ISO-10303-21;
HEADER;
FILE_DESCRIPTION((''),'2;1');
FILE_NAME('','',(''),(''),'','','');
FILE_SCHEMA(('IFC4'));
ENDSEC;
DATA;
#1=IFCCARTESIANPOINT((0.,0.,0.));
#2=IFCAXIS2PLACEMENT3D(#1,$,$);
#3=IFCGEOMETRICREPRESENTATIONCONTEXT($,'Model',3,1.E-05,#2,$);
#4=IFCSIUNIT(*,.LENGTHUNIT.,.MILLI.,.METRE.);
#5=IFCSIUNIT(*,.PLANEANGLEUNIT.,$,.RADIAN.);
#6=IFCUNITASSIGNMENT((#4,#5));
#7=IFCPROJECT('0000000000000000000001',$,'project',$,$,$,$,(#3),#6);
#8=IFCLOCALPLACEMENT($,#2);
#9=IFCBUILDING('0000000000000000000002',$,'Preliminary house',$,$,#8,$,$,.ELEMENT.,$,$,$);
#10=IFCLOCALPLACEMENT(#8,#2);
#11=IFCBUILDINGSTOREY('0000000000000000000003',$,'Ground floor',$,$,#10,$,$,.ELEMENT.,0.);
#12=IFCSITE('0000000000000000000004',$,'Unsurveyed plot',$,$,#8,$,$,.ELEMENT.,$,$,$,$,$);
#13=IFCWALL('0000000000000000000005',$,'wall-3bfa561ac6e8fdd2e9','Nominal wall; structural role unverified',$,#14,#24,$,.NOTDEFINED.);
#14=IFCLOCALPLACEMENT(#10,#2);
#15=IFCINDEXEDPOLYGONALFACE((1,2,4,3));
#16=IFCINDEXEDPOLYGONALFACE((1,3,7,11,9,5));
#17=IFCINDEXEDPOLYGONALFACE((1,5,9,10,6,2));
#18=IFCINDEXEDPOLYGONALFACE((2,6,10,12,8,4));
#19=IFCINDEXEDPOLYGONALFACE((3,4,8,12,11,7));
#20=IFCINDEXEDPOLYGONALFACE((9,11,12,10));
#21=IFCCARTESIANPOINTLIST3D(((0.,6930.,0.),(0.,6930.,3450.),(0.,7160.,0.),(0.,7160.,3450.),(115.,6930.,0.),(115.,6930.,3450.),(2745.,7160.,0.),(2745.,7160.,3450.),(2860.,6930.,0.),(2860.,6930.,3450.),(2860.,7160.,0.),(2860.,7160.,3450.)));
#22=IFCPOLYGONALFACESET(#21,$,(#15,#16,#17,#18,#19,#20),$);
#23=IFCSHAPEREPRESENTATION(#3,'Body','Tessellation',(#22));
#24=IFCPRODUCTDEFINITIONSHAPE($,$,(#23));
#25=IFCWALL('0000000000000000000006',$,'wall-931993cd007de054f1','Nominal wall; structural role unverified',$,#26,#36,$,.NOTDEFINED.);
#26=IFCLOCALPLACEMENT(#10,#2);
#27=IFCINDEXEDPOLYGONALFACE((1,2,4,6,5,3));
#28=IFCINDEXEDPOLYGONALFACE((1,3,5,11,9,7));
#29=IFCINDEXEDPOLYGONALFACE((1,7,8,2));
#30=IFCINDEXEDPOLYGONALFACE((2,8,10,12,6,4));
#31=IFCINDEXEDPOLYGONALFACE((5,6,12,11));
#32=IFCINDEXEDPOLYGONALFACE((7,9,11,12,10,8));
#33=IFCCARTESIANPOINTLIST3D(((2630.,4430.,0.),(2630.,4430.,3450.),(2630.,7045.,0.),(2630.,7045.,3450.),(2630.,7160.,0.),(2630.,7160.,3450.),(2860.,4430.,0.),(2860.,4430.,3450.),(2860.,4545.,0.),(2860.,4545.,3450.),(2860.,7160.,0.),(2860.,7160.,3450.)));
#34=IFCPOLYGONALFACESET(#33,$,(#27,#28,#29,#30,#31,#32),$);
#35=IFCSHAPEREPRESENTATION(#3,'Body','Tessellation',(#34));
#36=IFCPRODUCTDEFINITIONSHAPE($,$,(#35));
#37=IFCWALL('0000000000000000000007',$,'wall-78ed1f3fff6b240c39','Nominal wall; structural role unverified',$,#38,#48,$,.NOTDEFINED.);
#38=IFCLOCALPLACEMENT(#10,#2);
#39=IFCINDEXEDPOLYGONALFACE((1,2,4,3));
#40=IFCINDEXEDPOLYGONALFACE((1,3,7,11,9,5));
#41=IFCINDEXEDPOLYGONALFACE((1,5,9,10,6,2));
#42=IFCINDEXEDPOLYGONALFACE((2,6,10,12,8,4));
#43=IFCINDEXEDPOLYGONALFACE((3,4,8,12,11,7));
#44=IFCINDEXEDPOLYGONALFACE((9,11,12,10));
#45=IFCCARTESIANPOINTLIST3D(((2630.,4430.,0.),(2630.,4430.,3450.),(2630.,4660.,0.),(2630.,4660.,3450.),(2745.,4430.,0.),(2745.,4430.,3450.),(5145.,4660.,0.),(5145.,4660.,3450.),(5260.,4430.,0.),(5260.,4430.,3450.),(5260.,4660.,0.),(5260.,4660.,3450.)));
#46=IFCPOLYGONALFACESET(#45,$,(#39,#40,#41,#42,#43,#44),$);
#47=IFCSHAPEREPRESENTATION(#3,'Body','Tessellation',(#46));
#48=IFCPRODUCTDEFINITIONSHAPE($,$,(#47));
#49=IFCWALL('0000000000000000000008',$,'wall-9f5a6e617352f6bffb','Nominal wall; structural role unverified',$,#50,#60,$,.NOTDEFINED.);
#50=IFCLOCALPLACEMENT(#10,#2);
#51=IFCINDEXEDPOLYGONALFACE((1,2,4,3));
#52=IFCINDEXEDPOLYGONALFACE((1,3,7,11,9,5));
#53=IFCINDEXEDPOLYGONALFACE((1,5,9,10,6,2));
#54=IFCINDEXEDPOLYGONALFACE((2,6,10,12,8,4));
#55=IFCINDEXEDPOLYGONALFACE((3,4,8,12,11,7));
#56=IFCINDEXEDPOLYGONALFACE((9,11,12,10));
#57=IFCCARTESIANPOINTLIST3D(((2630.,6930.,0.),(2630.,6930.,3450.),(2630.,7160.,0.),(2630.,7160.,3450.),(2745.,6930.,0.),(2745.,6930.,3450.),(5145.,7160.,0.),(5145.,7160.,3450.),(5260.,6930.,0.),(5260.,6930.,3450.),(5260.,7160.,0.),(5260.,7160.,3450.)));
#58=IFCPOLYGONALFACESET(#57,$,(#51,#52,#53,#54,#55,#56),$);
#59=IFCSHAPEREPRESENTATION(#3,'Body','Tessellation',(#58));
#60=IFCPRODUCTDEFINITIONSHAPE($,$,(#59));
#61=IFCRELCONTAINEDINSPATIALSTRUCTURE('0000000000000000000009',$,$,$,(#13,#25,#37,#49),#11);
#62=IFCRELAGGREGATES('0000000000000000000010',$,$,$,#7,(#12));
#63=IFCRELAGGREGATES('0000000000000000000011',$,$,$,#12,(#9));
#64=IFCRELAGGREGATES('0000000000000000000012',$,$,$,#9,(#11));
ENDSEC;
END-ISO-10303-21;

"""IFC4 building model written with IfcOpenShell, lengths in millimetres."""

from ifc_helpers import new_model, si_unit, origin, place, context, project, spatial, polyline, outline, extrude, element, save


model = new_model("IFC4")

# Units and contexts
model_context = context("Model", 3, precision=1e-05, world=origin())
ifc_project = project(units=[si_unit("LENGTHUNIT", "METRE", prefix="MILLI"), si_unit("PLANEANGLEUNIT", "RADIAN")], contexts=[model_context])

# Site, building, storey
placement_1 = place(None, origin())
site = spatial("IfcSite", under=ifc_project, at=placement_1, Name="Unsurveyed plot", CompositionType="ELEMENT")
building = spatial("IfcBuilding", under=site, at=placement_1, Name="Preliminary house", CompositionType="ELEMENT")
placement_2 = place(placement_1, origin())
storey = spatial("IfcBuildingStorey", under=building, at=placement_2, Name="Ground floor", CompositionType="ELEMENT", Elevation=0.0)

# Wall
element("IfcWall", 1, at=placement_2, inside=storey, Name="wall-3bfa561ac6e8fdd2e9", Description="Nominal wall; structural role unverified", PredefinedType="NOTDEFINED", context=model_context, shape_type="SweptSolid", body=[
    extrude(outline(polyline([(2745.0, 7160.0), (2860.0, 7160.0), (2860.0, 6930.0), (115.0, 6930.0), (0.0, 6930.0), (0.0, 7160.0), (2745.0, 7160.0)])), origin(), (0.0, 0.0, 1.0), 3450.0),
])

# Walls
element("IfcWall", 2, at=placement_2, inside=storey, Name="wall-931993cd007de054f1", Description="Nominal wall; structural role unverified", PredefinedType="NOTDEFINED", context=model_context, shape_type="SweptSolid", body=[
    extrude(outline(polyline([(2630.0, 7045.0), (2630.0, 7160.0), (2860.0, 7160.0), (2860.0, 4545.0), (2860.0, 4430.0), (2630.0, 4430.0), (2630.0, 7045.0)])), origin(), (0.0, 0.0, 1.0), 3450.0),
])
element("IfcWall", 3, at=placement_2, inside=storey, Name="wall-78ed1f3fff6b240c39", Description="Nominal wall; structural role unverified", PredefinedType="NOTDEFINED", context=model_context, shape_type="SweptSolid", body=[
    extrude(outline(polyline([(5145.0, 4660.0), (5260.0, 4660.0), (5260.0, 4430.0), (2745.0, 4430.0), (2630.0, 4430.0), (2630.0, 4660.0), (5145.0, 4660.0)])), origin(), (0.0, 0.0, 1.0), 3450.0),
])
element("IfcWall", 4, at=placement_2, inside=storey, Name="wall-9f5a6e617352f6bffb", Description="Nominal wall; structural role unverified", PredefinedType="NOTDEFINED", context=model_context, shape_type="SweptSolid", body=[
    extrude(outline(polyline([(5145.0, 7160.0), (5260.0, 7160.0), (5260.0, 6930.0), (2745.0, 6930.0), (2630.0, 6930.0), (2630.0, 7160.0), (5145.0, 7160.0)])), origin(), (0.0, 0.0, 1.0), 3450.0),
])

save(model, "model.ifc")
